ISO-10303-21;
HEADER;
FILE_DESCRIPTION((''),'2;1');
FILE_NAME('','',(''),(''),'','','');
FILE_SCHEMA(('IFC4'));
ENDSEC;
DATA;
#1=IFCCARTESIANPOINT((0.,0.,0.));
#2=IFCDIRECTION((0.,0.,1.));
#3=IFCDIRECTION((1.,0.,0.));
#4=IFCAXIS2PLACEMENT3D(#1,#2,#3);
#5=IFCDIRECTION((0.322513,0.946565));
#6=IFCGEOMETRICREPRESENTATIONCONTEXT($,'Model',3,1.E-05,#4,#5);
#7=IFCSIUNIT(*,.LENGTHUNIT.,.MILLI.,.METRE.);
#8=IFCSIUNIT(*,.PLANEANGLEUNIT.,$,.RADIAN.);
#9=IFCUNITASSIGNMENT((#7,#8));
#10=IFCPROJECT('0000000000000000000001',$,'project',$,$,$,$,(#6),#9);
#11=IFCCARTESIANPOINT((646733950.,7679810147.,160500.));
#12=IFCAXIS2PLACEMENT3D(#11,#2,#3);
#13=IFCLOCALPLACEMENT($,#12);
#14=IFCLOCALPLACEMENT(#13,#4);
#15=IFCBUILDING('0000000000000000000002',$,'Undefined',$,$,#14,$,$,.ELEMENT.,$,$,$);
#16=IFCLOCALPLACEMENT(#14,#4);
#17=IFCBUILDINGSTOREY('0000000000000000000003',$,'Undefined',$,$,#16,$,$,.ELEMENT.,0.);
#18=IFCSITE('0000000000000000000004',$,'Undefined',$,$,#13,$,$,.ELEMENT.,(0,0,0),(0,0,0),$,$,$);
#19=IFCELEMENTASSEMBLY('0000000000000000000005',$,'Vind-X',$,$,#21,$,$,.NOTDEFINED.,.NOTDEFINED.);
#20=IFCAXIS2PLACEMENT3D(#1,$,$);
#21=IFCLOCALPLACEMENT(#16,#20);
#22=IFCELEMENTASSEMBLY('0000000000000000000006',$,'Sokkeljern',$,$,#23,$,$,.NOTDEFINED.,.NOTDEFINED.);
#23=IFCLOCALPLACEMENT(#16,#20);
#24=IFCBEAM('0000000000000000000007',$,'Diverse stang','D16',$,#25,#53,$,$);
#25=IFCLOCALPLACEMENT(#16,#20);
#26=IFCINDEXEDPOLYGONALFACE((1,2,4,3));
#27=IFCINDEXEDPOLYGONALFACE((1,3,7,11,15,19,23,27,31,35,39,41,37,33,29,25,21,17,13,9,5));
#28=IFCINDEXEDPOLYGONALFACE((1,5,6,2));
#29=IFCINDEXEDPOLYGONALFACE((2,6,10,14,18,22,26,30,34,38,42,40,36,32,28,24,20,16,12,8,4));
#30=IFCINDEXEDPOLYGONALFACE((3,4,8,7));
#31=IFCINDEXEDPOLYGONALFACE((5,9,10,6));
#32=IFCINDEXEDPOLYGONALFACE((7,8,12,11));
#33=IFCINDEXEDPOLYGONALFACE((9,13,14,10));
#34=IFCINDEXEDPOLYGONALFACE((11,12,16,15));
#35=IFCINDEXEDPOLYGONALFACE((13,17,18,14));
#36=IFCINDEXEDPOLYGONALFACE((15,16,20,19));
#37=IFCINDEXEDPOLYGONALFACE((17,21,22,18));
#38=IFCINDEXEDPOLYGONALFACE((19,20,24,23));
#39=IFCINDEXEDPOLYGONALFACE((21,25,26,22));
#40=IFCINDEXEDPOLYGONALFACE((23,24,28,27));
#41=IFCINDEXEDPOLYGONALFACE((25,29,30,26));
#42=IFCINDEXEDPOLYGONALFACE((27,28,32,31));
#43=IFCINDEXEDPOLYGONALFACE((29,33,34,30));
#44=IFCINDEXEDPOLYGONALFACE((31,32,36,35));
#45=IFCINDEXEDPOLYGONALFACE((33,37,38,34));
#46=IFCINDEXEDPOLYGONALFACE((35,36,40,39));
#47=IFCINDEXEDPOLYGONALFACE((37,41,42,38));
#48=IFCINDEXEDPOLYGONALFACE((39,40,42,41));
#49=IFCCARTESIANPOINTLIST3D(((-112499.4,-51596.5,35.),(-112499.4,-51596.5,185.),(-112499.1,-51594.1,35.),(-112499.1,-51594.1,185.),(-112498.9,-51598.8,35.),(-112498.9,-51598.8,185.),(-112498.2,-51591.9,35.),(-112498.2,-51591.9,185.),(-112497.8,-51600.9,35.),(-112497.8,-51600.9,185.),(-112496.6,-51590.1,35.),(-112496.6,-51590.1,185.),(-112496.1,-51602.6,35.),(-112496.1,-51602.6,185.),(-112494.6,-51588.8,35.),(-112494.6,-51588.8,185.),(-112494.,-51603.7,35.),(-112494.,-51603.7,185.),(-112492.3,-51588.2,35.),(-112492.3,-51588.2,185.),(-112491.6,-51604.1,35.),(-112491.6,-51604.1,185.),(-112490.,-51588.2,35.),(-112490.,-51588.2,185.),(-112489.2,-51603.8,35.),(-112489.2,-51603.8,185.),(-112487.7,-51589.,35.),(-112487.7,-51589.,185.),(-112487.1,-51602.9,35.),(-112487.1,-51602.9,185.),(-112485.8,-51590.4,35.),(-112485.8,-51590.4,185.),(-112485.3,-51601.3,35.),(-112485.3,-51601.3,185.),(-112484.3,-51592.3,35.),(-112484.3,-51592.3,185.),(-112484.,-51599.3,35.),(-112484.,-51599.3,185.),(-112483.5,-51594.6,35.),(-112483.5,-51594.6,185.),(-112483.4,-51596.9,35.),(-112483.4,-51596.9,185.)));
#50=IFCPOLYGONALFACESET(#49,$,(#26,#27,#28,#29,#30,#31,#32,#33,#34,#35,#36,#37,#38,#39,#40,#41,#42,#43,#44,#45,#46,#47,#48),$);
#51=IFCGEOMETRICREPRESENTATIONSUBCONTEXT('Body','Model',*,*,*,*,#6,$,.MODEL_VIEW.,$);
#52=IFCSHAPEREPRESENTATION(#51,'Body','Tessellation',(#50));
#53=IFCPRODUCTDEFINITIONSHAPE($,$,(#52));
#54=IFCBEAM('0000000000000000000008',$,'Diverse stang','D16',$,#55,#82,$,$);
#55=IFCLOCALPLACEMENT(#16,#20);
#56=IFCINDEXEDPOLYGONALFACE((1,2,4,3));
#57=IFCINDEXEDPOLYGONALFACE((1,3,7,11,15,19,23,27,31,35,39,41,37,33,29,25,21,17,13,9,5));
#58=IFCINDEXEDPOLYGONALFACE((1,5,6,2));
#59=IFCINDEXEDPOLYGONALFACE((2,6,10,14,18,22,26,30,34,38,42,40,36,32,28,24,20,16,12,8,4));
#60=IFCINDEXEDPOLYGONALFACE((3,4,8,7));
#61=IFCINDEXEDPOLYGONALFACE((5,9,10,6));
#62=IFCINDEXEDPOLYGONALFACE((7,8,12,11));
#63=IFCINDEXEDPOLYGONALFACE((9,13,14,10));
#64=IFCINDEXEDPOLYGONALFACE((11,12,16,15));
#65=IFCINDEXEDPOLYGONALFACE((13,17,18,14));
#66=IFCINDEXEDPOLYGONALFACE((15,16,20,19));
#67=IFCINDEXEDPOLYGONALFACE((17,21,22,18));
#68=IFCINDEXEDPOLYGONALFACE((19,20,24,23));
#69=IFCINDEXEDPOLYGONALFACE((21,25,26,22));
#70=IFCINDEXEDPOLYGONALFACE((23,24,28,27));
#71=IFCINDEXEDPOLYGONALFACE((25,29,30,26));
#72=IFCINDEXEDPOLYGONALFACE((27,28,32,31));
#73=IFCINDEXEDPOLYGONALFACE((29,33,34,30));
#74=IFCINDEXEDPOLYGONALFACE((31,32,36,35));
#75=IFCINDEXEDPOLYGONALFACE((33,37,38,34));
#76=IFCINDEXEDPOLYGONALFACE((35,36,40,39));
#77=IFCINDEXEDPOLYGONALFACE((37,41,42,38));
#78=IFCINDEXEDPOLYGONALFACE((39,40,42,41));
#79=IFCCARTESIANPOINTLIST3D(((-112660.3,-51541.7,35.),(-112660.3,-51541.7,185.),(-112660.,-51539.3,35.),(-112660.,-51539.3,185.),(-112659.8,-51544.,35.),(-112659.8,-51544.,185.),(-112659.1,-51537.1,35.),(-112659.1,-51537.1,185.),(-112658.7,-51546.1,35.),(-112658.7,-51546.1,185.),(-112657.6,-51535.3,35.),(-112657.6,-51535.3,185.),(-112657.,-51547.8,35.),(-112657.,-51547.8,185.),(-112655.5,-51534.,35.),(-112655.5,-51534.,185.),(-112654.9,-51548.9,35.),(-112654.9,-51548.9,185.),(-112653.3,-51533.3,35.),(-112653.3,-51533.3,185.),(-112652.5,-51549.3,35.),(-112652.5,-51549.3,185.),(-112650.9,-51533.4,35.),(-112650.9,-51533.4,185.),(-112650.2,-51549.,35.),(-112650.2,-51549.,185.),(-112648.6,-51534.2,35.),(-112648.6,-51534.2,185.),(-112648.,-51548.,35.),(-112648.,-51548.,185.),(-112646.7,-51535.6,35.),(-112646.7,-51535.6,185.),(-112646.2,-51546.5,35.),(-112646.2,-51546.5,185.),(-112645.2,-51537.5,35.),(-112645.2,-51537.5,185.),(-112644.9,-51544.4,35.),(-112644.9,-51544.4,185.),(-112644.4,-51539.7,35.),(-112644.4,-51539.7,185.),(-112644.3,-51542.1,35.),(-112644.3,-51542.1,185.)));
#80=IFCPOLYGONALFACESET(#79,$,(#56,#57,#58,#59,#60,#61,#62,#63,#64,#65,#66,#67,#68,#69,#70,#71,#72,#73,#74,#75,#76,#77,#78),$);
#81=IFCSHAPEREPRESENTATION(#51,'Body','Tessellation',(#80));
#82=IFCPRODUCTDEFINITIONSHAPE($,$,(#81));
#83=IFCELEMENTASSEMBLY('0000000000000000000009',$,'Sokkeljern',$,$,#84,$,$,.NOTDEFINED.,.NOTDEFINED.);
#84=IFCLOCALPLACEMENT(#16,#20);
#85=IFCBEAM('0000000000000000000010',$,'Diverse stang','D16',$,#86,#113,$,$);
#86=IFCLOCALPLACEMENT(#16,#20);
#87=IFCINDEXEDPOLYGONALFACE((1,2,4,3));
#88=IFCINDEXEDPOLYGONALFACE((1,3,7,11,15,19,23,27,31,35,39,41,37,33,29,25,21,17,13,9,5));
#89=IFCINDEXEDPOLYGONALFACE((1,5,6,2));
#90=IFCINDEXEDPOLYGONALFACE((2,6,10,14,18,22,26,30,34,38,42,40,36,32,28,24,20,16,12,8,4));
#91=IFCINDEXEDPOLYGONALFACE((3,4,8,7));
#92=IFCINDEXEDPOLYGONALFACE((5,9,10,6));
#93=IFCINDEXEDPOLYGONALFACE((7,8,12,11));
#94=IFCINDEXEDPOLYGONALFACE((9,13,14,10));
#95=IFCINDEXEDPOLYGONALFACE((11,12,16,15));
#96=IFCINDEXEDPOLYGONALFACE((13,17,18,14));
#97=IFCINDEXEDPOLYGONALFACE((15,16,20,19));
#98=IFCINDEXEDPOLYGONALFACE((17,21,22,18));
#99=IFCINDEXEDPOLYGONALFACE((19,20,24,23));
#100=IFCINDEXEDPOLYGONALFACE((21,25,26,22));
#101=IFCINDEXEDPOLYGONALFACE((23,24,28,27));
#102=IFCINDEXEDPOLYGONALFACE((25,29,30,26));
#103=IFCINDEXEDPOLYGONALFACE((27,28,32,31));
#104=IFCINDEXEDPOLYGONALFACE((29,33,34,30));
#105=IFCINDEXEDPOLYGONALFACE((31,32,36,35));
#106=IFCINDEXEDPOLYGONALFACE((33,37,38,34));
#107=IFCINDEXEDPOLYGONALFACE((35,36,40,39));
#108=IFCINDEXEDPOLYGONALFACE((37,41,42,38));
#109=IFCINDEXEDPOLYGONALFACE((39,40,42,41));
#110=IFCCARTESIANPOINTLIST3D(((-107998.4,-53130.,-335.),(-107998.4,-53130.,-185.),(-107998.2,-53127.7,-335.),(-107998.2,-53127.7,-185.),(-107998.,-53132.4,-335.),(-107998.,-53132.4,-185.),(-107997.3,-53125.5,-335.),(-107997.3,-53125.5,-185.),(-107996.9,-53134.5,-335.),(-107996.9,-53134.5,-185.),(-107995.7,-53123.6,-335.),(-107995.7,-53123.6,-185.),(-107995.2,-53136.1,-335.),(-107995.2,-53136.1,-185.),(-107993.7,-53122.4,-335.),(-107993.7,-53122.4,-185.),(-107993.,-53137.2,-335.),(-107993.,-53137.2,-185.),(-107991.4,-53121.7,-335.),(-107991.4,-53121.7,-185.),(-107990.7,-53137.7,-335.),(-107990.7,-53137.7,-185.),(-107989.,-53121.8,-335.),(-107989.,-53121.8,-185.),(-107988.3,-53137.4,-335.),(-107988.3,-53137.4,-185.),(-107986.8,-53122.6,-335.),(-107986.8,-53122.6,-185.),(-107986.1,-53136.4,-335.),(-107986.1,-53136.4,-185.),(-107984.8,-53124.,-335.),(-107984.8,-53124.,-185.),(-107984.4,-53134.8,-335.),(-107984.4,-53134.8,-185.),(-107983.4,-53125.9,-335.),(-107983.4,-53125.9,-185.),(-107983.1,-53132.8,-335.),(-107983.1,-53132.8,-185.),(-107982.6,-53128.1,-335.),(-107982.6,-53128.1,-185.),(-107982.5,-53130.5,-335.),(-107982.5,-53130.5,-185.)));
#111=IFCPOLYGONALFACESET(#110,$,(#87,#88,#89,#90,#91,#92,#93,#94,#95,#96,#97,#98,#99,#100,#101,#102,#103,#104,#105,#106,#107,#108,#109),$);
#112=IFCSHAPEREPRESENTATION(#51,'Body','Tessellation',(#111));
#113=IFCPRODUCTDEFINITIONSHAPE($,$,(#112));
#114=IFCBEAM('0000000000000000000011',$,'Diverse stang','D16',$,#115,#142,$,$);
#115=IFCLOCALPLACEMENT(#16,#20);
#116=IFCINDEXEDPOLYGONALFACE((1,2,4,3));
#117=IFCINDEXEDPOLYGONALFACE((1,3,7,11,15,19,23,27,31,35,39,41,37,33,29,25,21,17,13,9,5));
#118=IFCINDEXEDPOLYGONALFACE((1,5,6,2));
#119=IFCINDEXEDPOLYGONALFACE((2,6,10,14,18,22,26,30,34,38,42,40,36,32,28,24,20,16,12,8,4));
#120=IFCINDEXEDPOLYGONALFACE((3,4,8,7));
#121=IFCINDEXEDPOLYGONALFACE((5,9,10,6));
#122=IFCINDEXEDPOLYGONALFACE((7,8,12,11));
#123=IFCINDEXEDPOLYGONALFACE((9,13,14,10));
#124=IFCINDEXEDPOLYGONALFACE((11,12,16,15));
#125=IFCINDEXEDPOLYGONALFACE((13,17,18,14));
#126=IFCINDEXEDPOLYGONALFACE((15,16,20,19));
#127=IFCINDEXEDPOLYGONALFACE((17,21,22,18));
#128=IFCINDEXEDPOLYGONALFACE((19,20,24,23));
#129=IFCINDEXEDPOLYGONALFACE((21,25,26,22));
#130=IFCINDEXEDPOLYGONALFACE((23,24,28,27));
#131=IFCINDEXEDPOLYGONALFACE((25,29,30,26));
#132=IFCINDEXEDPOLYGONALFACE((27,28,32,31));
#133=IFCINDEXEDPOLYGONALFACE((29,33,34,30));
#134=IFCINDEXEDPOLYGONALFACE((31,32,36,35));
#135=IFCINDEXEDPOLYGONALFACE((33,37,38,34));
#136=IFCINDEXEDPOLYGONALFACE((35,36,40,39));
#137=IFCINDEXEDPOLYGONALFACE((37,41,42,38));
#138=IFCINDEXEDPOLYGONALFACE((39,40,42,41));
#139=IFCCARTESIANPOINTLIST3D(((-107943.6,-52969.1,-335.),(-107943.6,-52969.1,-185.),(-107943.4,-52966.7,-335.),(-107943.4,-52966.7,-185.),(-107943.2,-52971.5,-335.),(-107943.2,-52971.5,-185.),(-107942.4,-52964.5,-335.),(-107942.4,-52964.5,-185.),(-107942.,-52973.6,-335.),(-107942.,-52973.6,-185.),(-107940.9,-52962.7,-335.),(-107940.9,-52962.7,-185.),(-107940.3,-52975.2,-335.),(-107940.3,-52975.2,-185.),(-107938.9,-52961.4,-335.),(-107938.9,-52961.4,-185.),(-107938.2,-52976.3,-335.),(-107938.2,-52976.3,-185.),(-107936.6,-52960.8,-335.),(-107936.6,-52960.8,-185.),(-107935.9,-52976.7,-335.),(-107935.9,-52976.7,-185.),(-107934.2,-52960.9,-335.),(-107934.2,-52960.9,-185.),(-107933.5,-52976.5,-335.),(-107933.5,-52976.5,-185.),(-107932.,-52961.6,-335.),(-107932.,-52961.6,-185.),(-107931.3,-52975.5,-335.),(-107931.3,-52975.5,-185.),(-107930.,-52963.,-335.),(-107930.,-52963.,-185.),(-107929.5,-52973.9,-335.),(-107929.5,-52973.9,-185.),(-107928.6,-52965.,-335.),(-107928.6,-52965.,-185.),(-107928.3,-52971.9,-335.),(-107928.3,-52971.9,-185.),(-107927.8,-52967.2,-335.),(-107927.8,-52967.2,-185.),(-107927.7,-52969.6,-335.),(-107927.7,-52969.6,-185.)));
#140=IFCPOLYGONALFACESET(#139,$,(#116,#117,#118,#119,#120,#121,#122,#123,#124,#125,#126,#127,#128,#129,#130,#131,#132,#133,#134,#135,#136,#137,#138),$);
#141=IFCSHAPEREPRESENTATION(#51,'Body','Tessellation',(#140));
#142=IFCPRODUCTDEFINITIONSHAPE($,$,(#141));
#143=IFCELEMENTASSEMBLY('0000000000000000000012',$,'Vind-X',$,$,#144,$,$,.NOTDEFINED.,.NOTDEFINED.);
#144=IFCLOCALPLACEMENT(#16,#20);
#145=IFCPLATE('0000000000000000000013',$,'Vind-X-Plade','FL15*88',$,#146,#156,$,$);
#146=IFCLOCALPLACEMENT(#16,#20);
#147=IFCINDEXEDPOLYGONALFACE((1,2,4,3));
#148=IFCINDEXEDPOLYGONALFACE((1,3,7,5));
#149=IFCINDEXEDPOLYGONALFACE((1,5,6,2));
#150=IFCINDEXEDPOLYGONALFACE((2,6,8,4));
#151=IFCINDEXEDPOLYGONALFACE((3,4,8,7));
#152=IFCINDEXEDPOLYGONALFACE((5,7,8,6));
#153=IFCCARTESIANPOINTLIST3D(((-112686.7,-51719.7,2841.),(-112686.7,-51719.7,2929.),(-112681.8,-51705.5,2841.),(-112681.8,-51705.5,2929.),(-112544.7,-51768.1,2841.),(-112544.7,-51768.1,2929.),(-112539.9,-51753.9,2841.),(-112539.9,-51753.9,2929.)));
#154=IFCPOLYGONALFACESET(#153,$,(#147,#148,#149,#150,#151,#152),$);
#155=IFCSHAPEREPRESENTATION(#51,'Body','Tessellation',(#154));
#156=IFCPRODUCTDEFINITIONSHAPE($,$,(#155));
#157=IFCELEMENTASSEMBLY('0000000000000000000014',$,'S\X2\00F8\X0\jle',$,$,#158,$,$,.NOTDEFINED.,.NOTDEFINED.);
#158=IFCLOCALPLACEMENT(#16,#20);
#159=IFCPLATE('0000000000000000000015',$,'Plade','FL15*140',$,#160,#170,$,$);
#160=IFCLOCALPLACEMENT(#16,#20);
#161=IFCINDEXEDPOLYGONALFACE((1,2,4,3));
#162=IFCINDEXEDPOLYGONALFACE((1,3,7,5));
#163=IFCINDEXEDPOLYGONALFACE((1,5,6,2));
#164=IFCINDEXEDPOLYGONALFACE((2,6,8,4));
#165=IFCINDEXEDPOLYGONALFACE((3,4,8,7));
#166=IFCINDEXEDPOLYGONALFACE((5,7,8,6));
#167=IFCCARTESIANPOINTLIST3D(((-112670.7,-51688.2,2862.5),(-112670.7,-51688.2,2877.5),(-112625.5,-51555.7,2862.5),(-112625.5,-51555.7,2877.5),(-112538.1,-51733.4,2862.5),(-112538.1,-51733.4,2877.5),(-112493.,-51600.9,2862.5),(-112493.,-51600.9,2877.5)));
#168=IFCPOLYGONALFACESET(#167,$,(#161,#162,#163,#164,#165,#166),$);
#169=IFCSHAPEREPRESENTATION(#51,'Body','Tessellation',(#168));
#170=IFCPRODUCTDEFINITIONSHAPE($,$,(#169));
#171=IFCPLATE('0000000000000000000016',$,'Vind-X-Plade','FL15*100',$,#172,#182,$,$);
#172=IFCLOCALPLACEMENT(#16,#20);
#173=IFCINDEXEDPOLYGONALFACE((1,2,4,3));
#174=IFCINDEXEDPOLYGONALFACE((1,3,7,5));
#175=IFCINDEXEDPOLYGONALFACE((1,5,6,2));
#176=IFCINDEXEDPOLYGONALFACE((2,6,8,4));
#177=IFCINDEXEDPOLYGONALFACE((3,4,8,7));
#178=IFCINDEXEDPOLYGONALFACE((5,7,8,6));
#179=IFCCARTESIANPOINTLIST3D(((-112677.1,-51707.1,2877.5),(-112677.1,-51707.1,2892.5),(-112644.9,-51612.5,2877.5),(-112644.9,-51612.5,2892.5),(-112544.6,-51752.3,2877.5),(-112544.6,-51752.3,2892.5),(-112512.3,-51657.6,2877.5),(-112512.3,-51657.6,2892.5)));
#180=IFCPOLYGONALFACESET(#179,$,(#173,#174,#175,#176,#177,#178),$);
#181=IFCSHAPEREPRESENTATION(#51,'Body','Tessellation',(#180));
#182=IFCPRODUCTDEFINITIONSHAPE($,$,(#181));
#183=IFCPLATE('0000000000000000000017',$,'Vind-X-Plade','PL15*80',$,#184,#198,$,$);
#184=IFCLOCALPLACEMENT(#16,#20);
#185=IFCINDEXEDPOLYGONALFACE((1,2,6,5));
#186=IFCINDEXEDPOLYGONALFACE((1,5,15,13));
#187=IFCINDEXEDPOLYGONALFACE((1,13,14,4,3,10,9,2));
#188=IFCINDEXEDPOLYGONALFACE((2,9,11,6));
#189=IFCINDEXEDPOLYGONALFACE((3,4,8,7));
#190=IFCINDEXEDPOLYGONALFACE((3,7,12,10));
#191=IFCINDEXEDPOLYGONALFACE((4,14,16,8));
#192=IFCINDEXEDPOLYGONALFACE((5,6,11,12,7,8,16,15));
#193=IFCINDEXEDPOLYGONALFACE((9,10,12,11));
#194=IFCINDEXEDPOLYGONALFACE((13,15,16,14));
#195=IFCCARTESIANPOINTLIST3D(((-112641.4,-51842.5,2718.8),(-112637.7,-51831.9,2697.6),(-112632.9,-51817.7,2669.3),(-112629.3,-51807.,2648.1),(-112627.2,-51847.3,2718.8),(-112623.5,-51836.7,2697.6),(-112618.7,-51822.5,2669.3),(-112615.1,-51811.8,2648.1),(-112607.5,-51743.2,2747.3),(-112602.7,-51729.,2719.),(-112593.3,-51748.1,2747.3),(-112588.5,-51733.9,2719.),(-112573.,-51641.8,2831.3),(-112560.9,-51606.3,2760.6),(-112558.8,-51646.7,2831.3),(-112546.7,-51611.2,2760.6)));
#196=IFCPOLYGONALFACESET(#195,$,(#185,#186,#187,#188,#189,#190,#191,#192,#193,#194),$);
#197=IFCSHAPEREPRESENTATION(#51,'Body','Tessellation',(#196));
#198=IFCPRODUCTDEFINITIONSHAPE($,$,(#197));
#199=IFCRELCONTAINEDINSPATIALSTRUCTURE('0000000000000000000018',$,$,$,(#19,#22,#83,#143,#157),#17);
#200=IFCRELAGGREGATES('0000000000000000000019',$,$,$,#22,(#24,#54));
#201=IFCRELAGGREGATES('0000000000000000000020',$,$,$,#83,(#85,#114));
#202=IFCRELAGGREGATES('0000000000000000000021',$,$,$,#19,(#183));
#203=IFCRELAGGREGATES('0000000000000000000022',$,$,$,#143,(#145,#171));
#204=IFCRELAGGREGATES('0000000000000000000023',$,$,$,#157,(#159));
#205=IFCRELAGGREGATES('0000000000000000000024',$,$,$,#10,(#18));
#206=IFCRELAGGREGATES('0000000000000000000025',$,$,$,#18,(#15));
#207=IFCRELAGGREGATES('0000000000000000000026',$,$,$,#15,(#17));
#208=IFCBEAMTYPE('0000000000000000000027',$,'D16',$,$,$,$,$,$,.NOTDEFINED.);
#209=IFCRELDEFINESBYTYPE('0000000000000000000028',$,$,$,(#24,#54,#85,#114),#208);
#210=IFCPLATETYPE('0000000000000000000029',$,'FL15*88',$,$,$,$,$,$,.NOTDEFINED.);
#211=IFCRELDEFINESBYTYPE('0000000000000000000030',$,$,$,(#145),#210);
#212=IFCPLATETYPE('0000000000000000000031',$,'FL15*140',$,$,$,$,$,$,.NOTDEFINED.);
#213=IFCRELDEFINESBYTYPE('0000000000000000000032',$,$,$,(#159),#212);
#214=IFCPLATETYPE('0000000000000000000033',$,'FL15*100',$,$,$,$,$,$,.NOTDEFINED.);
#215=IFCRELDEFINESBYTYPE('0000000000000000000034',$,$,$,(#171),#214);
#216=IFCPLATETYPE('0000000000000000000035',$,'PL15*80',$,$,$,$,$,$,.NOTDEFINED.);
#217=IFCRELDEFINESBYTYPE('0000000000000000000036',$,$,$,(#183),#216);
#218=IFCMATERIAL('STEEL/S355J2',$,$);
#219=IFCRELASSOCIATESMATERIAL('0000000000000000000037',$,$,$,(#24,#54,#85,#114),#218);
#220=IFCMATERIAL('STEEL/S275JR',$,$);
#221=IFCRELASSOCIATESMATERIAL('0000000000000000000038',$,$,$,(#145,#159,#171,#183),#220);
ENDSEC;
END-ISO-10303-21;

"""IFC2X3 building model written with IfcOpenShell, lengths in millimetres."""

from ifc_helpers import new_model, si_unit, direction, frame, origin_with_axes, origin_2d_with_axis, place, context, subcontext, project, spatial, polyline, circle, outline, extrude, boolean, material, type_object, element, aggregate, save


model = new_model("IFC2X3")

# Units and contexts
model_context = context("Model", 3, precision=1e-05, world=origin_with_axes(), true_north=direction((0.322513, 0.946565)))
body_context = subcontext(model_context, "Body", "Model", "MODEL_VIEW")
ifc_project = project(units=[si_unit("LENGTHUNIT", "METRE", prefix="MILLI"), si_unit("PLANEANGLEUNIT", "RADIAN")], contexts=[model_context])

# Site, building, storey
site_placement = place(None, frame((646733950.0, 7679810147.0, 160500.0), z_axis=(0.0, 0.0, 1.0), x_axis=(1.0, 0.0, 0.0)))
site = spatial("IfcSite", under=ifc_project, at=site_placement, Name="Undefined", CompositionType="ELEMENT", RefLatitude=(0, 0, 0), RefLongitude=(0, 0, 0))
building_placement = place(site_placement, origin_with_axes())
building = spatial("IfcBuilding", under=site, at=building_placement, Name="Undefined", CompositionType="ELEMENT")
storey_placement = place(building_placement, origin_with_axes())
storey = spatial("IfcBuildingStorey", under=building, at=storey_placement, Name="Undefined", CompositionType="ELEMENT", Elevation=0.0)

# Element assembly
assembly_1_placement = place(storey_placement, origin_with_axes())
assembly_1 = element("IfcElementAssembly", 1, at=assembly_1_placement, inside=storey, Name="Vind-X", AssemblyPlace="NOTDEFINED", PredefinedType="NOTDEFINED")
ifc_material_1 = material(Name="STEEL/S355J2")

# Shared definitions
ifc_material_2 = material(Name="STEEL/S275JR")

# Element assemblies, beams
assembly_2_placement = place(storey_placement, origin_with_axes())
assembly_2 = element("IfcElementAssembly", 2, at=assembly_2_placement, inside=storey, Name="Sokkeljern", AssemblyPlace="NOTDEFINED", PredefinedType="NOTDEFINED")
beam_type_1 = type_object("IfcBeamType", Name="D16", PredefinedType="NOTDEFINED")
beam_1_placement = place(assembly_2_placement, frame((-112491.4, -51596.1, 185.0), z_axis=(0.946565, -0.322513, 0.0), x_axis=(0.0, 0.0, -1.0)))
beam_1 = element("IfcBeam", 3, at=beam_1_placement, type_object=beam_type_1, material=ifc_material_1, Name="Diverse stang", Description="D16", context=body_context, shape_type="SweptSolid", body=[
    extrude(circle(Radius=8.0, at=origin_2d_with_axis()), frame((150.0, 0.0, 0.0), z_axis=(-1.0, 0.0, 0.0), x_axis=(0.0, -1.0, 0.0)), (0.0, 0.0, 1.0), 150.0),
])
beam_2_placement = place(assembly_2_placement, frame((-112652.3, -51541.3, 185.0), z_axis=(0.946565, -0.322513, 0.0), x_axis=(0.0, 0.0, -1.0)))
beam_2 = element("IfcBeam", 4, at=beam_2_placement, type_object=beam_type_1, material=ifc_material_1, Name="Diverse stang", Description="D16", context=body_context, shape_type="SweptSolid", body=[
    extrude(circle(Radius=8.0, at=origin_2d_with_axis()), frame((150.0, 0.0, 0.0), z_axis=(-1.0, 0.0, 0.0), x_axis=(0.0, -1.0, 0.0)), (0.0, 0.0, 1.0), 150.0),
])
aggregate(assembly_2, [beam_1, beam_2])
assembly_3_placement = place(storey_placement, origin_with_axes())
assembly_3 = element("IfcElementAssembly", 5, at=assembly_3_placement, inside=storey, Name="Sokkeljern", AssemblyPlace="NOTDEFINED", PredefinedType="NOTDEFINED")
beam_3_placement = place(assembly_3_placement, frame((-107990.5, -53129.7, -185.0), z_axis=(0.946565, -0.322513, 0.0), x_axis=(0.0, 0.0, -1.0)))
beam_3 = element("IfcBeam", 6, at=beam_3_placement, type_object=beam_type_1, material=ifc_material_1, Name="Diverse stang", Description="D16", context=body_context, shape_type="SweptSolid", body=[
    extrude(circle(Radius=8.0, at=origin_2d_with_axis()), frame((150.0, 0.0, 0.0), z_axis=(-1.0, 0.0, 0.0), x_axis=(0.0, -1.0, 0.0)), (0.0, 0.0, 1.0), 150.0),
])
beam_4_placement = place(assembly_3_placement, frame((-107935.6, -52968.7, -185.0), z_axis=(0.946565, -0.322513, 0.0), x_axis=(0.0, 0.0, -1.0)))
beam_4 = element("IfcBeam", 7, at=beam_4_placement, type_object=beam_type_1, material=ifc_material_1, Name="Diverse stang", Description="D16", context=body_context, shape_type="SweptSolid", body=[
    extrude(circle(Radius=8.0, at=origin_2d_with_axis()), frame((150.0, 0.0, 0.0), z_axis=(-1.0, 0.0, 0.0), x_axis=(0.0, -1.0, 0.0)), (0.0, 0.0, 1.0), 150.0),
])

# Element assemblies, plates
assembly_4_placement = place(storey_placement, origin_with_axes())
assembly_4 = element("IfcElementAssembly", 8, at=assembly_4_placement, inside=storey, Name="Vind-X", AssemblyPlace="NOTDEFINED", PredefinedType="NOTDEFINED")
plate_type_1 = type_object("IfcPlateType", Name="FL15*88", PredefinedType="NOTDEFINED")
plate_1_placement = place(assembly_4_placement, frame((-112542.3, -51761.0, 2841.0), z_axis=(0.322513, 0.946565, 0.0), x_axis=(-0.946565, 0.322513, 0.0)))
plate_1 = element("IfcPlate", 9, at=plate_1_placement, type_object=plate_type_1, material=ifc_material_2, Name="Vind-X-Plade", Description="FL15*88", context=body_context, shape_type="SweptSolid", body=[
    extrude(outline(polyline([(0.0, 0.0), (150.0, 0.0), (150.0, 88.0), (0.0, 88.0), (0.0, 0.0)])), frame((0.0, 0.0, -7.5), z_axis=(0.0, 0.0, 1.0), x_axis=(1.0, 0.0, 0.0)), (0.0, 0.0, 1.0), 15.0),
])
assembly_5_placement = place(storey_placement, origin_with_axes())
assembly_5 = element("IfcElementAssembly", 10, at=assembly_5_placement, inside=storey, Name="Søjle", AssemblyPlace="NOTDEFINED", PredefinedType="NOTDEFINED")
plate_type_2 = type_object("IfcPlateType", Name="FL15*140", PredefinedType="NOTDEFINED")
plate_2_placement = place(assembly_5_placement, frame((-112493.0, -51600.9, 2870.0), z_axis=(0.0, 0.0, 1.0), x_axis=(-0.946565, 0.322513, 0.0)))
plate_2 = element("IfcPlate", 11, at=plate_2_placement, type_object=plate_type_2, material=ifc_material_2, Name="Plade", Description="FL15*140", context=body_context, shape_type="SweptSolid", body=[
    extrude(outline(polyline([(0.0, 0.0), (140.0, 0.0), (140.0, 140.0), (0.0, 140.0), (0.0, 0.0)])), frame((0.0, 0.0, -7.5), z_axis=(0.0, 0.0, 1.0), x_axis=(1.0, 0.0, 0.0)), (0.0, 0.0, 1.0), 15.0),
])

# Plates
plate_type_3 = type_object("IfcPlateType", Name="FL15*100", PredefinedType="NOTDEFINED")
plate_3_placement = place(assembly_4_placement, frame((-112578.6, -51635.1, 2885.0), z_axis=(0.0, 0.0, -1.0), x_axis=(-0.322513, -0.946565, 0.0)))
plate_3 = element("IfcPlate", 12, at=plate_3_placement, type_object=plate_type_3, material=ifc_material_2, Name="Vind-X-Plade", Description="FL15*100", context=body_context, shape_type="SweptSolid", body=[
    extrude(outline(polyline([(0.0, -70.0), (0.0, 70.0), (100.0, 70.0), (100.0, -70.0), (0.0, -70.0)])), frame((0.0, 0.0, -7.5), z_axis=(0.0, 0.0, 1.0), x_axis=(1.0, 0.0, 0.0)), (0.0, 0.0, 1.0), 15.0),
])
plate_type_4 = type_object("IfcPlateType", Name="PL15*80", PredefinedType="NOTDEFINED")
plate_4_placement = place(assembly_1_placement, frame((-112553.8, -51608.8, 2760.6), z_axis=(0.946565, -0.322513, 0.0), x_axis=(-0.151189, -0.443735, 0.883313)))
plate_4 = element("IfcPlate", 13, at=plate_4_placement, type_object=plate_type_4, material=ifc_material_2, Name="Vind-X-Plade", Description="PL15*80", context=body_context, shape_type="CSG", body=[
    boolean("DIFFERENCE", extrude(outline(polyline([(0.0, 0.0), (80.0, 0.0), (80.0, 240.0), (0.0, 240.0), (0.0, 0.0)])), frame((0.0, 0.0, -7.5), z_axis=(0.0, 0.0, 1.0), x_axis=(1.0, 0.0, 0.0)), (0.0, 0.0, 1.0), 15.0), extrude(outline(polyline([(0.0, 0.0), (106.0, 0.0), (106.0, 32.0), (0.0, 32.0), (0.0, 0.0)])), frame((56.0, 240.0, 8.5), z_axis=(0.0, 0.0, -1.0), x_axis=(0.0, -1.0, 0.0)), (0.0, 0.0, 1.0), 17.0)),
])

aggregate(assembly_3, [beam_3, beam_4])

aggregate(assembly_1, [plate_4])
aggregate(assembly_4, [plate_1, plate_3])
aggregate(assembly_5, [plate_2])

save(model, "model.ifc")
